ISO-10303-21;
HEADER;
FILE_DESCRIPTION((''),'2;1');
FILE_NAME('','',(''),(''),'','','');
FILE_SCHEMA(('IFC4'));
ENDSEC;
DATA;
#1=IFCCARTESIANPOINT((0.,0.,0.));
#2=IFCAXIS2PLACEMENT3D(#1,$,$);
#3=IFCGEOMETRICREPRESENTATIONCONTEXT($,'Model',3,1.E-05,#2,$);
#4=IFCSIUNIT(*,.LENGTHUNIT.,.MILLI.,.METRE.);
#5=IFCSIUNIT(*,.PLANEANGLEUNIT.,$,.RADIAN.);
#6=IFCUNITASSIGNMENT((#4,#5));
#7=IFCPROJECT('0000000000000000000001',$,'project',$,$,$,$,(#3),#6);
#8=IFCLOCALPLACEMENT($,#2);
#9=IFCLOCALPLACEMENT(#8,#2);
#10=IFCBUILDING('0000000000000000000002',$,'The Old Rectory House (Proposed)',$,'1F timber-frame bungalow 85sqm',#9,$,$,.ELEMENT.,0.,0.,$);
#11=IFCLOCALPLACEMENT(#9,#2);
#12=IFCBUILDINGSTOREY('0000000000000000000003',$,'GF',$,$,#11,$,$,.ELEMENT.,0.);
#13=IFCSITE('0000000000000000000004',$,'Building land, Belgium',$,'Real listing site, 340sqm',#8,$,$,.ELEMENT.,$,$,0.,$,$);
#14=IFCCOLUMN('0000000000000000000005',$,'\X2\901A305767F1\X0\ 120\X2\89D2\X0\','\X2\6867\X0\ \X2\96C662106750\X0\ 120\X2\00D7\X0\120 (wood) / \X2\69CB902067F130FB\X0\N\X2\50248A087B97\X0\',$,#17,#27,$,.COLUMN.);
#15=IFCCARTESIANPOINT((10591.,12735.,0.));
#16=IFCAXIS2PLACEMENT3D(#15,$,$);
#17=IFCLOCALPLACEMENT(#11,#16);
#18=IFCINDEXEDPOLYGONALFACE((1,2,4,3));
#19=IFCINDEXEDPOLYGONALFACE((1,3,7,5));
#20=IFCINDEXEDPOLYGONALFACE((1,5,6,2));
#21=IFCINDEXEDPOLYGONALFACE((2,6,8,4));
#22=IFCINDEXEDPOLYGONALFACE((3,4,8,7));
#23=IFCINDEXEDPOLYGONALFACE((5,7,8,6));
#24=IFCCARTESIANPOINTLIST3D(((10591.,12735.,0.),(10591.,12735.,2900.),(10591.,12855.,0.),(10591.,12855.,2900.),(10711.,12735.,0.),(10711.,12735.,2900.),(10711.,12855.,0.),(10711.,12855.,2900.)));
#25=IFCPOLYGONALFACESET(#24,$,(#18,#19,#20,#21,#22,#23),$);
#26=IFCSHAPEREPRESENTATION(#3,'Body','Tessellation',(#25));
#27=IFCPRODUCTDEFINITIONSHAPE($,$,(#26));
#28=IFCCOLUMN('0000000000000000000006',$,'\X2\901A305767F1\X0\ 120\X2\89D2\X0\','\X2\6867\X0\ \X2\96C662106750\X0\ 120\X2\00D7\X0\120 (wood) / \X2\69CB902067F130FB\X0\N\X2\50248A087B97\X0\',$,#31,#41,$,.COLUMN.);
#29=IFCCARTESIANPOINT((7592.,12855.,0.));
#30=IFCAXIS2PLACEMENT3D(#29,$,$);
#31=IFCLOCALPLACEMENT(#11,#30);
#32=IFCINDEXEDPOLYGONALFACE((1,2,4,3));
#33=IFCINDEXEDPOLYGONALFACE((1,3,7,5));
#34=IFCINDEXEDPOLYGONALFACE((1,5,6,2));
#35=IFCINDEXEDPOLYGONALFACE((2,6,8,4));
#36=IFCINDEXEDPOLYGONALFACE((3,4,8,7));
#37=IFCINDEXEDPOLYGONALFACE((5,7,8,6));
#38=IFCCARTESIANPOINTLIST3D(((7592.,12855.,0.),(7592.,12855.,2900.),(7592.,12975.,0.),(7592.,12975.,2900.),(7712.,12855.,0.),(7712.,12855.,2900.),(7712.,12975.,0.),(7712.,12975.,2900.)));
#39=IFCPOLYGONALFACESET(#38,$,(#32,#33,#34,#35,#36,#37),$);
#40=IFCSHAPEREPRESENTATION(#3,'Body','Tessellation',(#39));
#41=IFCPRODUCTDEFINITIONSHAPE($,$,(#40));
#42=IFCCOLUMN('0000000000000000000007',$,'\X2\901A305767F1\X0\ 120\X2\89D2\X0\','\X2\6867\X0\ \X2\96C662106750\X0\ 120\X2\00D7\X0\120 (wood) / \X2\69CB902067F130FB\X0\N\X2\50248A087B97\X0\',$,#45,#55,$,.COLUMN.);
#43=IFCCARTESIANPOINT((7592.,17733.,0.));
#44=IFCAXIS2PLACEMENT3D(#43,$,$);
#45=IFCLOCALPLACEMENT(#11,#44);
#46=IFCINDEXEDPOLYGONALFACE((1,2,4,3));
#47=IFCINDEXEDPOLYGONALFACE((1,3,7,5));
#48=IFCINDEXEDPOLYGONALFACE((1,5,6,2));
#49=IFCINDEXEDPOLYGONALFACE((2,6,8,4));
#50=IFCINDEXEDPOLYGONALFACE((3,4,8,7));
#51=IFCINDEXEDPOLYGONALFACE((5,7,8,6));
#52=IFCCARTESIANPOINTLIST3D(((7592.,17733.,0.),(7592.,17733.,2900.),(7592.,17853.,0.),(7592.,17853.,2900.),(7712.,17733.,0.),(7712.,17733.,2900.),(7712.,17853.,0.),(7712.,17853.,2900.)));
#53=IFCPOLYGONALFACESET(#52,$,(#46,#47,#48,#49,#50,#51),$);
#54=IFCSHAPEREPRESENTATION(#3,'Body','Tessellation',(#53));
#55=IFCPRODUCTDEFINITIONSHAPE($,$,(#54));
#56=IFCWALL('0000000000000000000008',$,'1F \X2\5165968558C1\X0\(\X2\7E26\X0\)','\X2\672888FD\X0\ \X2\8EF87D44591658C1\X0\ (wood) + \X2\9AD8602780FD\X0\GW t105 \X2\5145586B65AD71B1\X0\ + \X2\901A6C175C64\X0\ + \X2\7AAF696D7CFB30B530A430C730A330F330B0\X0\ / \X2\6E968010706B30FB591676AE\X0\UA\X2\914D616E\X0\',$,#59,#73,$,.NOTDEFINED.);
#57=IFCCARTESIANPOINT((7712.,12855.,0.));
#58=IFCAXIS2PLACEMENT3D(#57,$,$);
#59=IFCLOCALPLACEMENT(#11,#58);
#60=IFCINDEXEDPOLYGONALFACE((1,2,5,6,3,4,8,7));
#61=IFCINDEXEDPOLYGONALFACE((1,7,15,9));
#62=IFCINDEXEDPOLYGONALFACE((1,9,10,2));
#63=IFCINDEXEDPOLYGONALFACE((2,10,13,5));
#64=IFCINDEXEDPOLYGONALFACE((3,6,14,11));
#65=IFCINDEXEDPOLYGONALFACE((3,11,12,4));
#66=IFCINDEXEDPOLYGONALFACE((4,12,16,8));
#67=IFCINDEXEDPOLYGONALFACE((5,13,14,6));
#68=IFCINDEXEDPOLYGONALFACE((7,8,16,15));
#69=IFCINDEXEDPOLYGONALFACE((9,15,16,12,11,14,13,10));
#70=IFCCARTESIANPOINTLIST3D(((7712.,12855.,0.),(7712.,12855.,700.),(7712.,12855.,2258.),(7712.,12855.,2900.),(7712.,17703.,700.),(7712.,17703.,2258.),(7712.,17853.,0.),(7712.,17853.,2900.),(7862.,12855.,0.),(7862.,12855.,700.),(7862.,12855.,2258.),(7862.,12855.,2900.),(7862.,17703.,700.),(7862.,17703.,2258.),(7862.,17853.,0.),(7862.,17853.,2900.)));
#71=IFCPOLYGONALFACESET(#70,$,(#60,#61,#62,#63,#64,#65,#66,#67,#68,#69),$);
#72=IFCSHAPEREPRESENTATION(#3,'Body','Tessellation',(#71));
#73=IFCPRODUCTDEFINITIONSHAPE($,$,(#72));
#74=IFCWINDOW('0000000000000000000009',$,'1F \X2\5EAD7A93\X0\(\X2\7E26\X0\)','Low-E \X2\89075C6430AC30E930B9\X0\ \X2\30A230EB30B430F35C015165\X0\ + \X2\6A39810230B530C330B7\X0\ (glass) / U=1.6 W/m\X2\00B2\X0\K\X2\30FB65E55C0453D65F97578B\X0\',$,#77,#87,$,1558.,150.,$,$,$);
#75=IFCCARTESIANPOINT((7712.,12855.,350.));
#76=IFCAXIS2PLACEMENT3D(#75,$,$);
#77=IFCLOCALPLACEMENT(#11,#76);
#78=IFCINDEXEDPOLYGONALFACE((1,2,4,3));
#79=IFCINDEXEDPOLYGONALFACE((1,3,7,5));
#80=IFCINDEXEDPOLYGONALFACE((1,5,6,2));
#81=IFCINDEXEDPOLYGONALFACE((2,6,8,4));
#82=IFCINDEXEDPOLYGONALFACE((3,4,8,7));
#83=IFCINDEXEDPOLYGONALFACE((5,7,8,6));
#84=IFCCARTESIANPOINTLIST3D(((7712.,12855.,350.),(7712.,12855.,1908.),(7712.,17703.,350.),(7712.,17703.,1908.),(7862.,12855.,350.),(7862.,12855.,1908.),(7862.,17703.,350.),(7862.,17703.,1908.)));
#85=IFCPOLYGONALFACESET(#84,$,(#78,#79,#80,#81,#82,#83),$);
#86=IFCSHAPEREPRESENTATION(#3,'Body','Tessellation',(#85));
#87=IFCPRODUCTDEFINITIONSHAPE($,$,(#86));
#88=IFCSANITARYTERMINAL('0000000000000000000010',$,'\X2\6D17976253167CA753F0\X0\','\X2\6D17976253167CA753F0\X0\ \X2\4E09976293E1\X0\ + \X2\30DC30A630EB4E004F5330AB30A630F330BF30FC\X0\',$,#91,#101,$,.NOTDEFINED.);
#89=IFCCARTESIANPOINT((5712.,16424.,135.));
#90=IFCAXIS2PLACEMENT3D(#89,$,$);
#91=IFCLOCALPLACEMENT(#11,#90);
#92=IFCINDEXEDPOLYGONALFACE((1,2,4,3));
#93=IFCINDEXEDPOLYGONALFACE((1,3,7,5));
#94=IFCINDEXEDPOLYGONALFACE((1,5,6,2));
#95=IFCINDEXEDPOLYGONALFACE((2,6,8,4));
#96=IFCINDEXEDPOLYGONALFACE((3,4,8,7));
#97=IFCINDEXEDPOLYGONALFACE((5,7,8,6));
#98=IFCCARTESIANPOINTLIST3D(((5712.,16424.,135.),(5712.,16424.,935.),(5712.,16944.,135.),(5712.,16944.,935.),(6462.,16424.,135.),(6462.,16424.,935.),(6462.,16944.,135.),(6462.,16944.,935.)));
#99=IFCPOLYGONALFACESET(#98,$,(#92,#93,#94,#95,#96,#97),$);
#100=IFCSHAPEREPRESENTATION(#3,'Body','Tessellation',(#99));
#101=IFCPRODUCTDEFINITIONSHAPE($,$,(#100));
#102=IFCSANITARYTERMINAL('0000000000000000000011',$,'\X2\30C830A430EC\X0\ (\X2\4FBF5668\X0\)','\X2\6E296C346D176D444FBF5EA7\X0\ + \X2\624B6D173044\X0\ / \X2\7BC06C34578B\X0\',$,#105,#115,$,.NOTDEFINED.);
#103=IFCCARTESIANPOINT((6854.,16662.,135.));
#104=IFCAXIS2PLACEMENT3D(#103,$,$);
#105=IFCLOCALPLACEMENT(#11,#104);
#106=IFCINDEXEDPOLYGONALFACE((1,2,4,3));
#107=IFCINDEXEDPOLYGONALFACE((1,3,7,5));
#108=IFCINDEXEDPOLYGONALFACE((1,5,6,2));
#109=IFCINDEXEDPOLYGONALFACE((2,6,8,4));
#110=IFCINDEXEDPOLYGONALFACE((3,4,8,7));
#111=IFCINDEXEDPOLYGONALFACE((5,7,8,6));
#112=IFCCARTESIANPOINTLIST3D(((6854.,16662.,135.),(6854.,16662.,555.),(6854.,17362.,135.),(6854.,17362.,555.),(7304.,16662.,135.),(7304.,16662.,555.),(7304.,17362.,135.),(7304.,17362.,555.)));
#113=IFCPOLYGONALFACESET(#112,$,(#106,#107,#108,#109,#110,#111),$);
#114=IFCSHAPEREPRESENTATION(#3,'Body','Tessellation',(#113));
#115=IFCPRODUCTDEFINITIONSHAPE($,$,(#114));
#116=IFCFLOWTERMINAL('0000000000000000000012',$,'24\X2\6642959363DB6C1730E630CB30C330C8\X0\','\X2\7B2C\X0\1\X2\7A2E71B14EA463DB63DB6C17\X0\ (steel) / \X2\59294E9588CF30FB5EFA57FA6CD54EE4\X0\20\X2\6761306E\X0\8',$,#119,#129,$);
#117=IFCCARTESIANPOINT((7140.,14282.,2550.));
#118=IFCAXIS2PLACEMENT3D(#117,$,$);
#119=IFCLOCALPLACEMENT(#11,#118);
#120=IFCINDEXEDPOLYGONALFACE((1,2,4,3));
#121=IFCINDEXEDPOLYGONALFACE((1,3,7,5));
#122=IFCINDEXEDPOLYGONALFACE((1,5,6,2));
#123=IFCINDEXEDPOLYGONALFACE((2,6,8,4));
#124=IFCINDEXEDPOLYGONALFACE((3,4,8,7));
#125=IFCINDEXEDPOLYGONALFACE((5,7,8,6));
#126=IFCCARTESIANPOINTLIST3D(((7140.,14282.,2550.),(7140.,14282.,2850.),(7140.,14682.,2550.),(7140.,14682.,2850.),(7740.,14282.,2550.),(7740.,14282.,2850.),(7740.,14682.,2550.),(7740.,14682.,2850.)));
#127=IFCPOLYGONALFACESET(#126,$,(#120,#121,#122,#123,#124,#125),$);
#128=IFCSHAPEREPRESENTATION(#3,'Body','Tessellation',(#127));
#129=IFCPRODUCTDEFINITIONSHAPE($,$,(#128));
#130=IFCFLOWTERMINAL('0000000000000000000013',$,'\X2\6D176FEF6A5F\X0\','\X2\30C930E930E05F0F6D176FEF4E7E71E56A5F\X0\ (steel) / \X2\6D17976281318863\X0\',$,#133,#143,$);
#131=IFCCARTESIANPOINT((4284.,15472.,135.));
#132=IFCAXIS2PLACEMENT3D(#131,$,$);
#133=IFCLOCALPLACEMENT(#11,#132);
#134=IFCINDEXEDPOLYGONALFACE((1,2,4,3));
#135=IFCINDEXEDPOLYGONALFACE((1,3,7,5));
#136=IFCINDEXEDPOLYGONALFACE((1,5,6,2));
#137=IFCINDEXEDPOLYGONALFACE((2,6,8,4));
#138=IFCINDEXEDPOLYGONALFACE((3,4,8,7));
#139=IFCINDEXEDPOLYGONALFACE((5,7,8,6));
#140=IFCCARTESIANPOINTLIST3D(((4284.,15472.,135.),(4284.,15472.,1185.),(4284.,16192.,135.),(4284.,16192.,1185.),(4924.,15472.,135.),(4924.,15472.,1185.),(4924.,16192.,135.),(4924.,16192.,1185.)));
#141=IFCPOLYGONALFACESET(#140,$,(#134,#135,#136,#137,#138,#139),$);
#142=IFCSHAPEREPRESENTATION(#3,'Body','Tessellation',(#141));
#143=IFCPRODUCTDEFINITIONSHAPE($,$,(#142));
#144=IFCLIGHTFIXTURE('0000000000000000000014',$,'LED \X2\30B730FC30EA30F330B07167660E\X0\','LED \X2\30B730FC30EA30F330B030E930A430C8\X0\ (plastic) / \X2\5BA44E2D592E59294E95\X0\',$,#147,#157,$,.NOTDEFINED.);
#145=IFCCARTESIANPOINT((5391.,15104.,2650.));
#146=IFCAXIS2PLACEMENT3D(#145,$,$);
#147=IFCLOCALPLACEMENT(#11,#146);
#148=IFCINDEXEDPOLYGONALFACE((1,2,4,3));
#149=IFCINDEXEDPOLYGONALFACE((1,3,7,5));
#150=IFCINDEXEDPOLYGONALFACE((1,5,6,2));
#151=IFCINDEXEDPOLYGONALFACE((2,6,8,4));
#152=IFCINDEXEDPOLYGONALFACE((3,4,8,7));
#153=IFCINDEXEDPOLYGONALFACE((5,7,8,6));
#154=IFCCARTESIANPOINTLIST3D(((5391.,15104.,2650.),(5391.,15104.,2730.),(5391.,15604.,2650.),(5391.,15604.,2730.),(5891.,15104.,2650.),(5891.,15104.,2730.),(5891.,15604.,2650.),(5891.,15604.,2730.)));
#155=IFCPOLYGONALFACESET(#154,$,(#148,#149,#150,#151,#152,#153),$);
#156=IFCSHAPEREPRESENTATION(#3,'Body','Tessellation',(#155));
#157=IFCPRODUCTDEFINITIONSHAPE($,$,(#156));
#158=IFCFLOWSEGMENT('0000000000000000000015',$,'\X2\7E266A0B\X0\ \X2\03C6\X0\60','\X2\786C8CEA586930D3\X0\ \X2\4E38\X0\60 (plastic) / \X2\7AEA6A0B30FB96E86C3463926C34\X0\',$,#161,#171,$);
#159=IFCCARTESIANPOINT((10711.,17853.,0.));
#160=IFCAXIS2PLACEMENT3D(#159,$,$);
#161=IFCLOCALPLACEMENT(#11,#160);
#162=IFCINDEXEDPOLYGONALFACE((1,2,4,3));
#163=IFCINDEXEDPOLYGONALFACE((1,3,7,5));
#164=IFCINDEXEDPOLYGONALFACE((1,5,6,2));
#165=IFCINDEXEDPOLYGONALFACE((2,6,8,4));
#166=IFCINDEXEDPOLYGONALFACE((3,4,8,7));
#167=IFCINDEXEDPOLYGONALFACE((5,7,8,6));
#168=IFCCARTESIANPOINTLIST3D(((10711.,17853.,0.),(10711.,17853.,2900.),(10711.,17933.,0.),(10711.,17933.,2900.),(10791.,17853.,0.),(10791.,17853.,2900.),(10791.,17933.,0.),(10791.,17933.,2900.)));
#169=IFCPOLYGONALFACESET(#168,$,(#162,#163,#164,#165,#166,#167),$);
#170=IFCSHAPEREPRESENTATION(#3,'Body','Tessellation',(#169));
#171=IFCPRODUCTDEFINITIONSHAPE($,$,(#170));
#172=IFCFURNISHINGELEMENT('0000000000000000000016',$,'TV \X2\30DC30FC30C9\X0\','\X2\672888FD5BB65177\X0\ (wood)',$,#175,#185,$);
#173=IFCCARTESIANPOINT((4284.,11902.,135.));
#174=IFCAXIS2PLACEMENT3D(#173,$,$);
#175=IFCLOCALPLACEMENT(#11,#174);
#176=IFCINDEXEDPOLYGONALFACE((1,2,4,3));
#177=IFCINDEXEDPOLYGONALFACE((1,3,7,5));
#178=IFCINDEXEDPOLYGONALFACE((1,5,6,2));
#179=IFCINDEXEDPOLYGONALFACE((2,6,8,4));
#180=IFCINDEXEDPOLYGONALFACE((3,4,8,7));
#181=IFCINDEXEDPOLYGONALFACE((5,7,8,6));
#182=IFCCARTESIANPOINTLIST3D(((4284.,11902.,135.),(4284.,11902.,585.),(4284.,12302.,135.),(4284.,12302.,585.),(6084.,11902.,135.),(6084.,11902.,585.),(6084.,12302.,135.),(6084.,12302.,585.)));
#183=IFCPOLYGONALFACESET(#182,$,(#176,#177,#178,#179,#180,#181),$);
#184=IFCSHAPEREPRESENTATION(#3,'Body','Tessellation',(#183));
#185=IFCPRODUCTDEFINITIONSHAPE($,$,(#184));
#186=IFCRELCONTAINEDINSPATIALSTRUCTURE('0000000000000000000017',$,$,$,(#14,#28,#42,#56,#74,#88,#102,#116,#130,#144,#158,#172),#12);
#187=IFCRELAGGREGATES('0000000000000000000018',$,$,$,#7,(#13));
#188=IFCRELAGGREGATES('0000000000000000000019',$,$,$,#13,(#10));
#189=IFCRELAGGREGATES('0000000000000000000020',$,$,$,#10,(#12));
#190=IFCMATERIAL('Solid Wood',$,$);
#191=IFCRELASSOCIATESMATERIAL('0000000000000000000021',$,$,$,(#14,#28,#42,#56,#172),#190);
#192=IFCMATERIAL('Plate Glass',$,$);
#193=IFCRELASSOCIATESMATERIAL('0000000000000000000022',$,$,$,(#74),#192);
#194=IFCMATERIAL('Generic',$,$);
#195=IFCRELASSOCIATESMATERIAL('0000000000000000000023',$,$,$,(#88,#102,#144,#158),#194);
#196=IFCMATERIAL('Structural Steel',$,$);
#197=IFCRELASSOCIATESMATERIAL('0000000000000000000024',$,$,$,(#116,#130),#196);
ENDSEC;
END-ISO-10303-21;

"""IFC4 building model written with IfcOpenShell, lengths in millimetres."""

from ifc_helpers import new_model, si_unit, frame, frame_2d, origin, place, context, project, spatial, rectangle, extrude, material, element, fill, save


model = new_model("IFC4")

# Units and contexts
model_context = context("Model", 3, precision=1e-05, world=origin())
ifc_project = project(units=[si_unit("LENGTHUNIT", "METRE", prefix="MILLI"), si_unit("PLANEANGLEUNIT", "RADIAN")], contexts=[model_context])

# Site, building, storey
site_placement = place(None, origin())
site = spatial("IfcSite", under=ifc_project, at=site_placement, Name="Building land, Belgium", ObjectType="Real listing site, 340sqm", CompositionType="ELEMENT", RefElevation=0.0)
building_placement = place(site_placement, origin())
building = spatial("IfcBuilding", under=site, at=building_placement, Name="The Old Rectory House (Proposed)", ObjectType="1F timber-frame bungalow 85sqm", CompositionType="ELEMENT", ElevationOfRefHeight=0.0, ElevationOfTerrain=0.0)
storey_placement = place(building_placement, origin())
storey = spatial("IfcBuildingStorey", under=building, at=storey_placement, Name="GF", CompositionType="ELEMENT", Elevation=0.0)

# Columns
ifc_material_1 = material(Name="Solid Wood")
column_1_placement = place(storey_placement, frame((10591.0, 12735.0, 0.0)))
element("IfcColumn", 1, at=column_1_placement, inside=storey, material=ifc_material_1, Name="通し柱 120角", Description="桧 集成材 120×120 (wood) / 構造柱・N値計算", PredefinedType="COLUMN", context=model_context, shape_type="SweptSolid", body=[
    extrude(rectangle(XDim=120.0, YDim=120.0, at=frame_2d((60.0, 60.0))), frame((10591.0, 12735.0, 0.0)), (0.0, 0.0, 1.0), 2900.0),
])
column_2_placement = place(storey_placement, frame((7592.0, 12855.0, 0.0)))
element("IfcColumn", 2, at=column_2_placement, inside=storey, material=ifc_material_1, Name="通し柱 120角", Description="桧 集成材 120×120 (wood) / 構造柱・N値計算", PredefinedType="COLUMN", context=model_context, shape_type="SweptSolid", body=[
    extrude(rectangle(XDim=120.0, YDim=120.0, at=frame_2d((60.0, 60.0))), frame((7592.0, 12855.0, 0.0)), (0.0, 0.0, 1.0), 2900.0),
])
column_3_placement = place(storey_placement, frame((7592.0, 17733.0, 0.0)))
element("IfcColumn", 3, at=column_3_placement, inside=storey, material=ifc_material_1, Name="通し柱 120角", Description="桧 集成材 120×120 (wood) / 構造柱・N値計算", PredefinedType="COLUMN", context=model_context, shape_type="SweptSolid", body=[
    extrude(rectangle(XDim=120.0, YDim=120.0, at=frame_2d((60.0, 60.0))), frame((7592.0, 17733.0, 0.0)), (0.0, 0.0, 1.0), 2900.0),
])

# Wall, opening, window
wall_1_placement = place(storey_placement, frame((7712.0, 12855.0, 0.0)))
wall_1 = element("IfcWall", 4, at=wall_1_placement, inside=storey, material=ifc_material_1, Name="1F 入隅壁(縦)", Description="木製 軸組外壁 (wood) + 高性能GW t105 充填断熱 + 通気層 + 窯業系サイディング / 準耐火・外皮UA配慮", PredefinedType="NOTDEFINED", context=model_context, shape_type="SweptSolid", body=[
    extrude(rectangle(XDim=150.0, YDim=4998.0, at=frame_2d((75.0, 2499.0))), frame((7712.0, 12855.0, 0.0)), (0.0, 0.0, 1.0), 2900.0),
])
opening_placement = place(storey_placement, frame((7712.0, 12855.0, 350.0)))
opening = element("IfcOpeningElement", 5, at=opening_placement, cuts=wall_1, PredefinedType="NOTDEFINED", context=model_context, shape_type="SweptSolid", body=[
    extrude(rectangle(XDim=150.0, YDim=4848.0, at=frame_2d((75.0, 2424.0))), frame((7712.0, 12855.0, 350.0)), (0.0, 0.0, 1.0), 1558.0),
])
ifc_material_2 = material(Name="Plate Glass")
window_placement = place(storey_placement, frame((7712.0, 12855.0, 350.0)))
window = element("IfcWindow", 6, at=window_placement, inside=storey, material=ifc_material_2, Name="1F 庭窓(縦)", Description="Low-E 複層ガラス アルゴン封入 + 樹脂サッシ (glass) / U=1.6 W/m²K・日射取得型", OverallHeight=1558.0, OverallWidth=150.0, context=model_context, shape_type="SweptSolid", body=[
    extrude(rectangle(XDim=150.0, YDim=4848.0, at=frame_2d((75.0, 2424.0))), frame((7712.0, 12855.0, 350.0)), (0.0, 0.0, 1.0), 1558.0),
])
fill(opening, window)

# Sanitary terminals
ifc_material_3 = material(Name="Generic")
sanitary_terminal_1_placement = place(storey_placement, frame((5712.0, 16424.0, 135.0)))
element("IfcSanitaryTerminal", 7, at=sanitary_terminal_1_placement, inside=storey, material=ifc_material_3, Name="洗面化粧台", Description="洗面化粧台 三面鏡 + ボウル一体カウンター", PredefinedType="NOTDEFINED", context=model_context, shape_type="SweptSolid", body=[
    extrude(rectangle(XDim=750.0, YDim=520.0, at=frame_2d((375.0, 260.0))), frame((5712.0, 16424.0, 135.0)), (0.0, 0.0, 1.0), 800.0),
])
sanitary_terminal_2_placement = place(storey_placement, frame((6854.0, 16662.0, 135.0)))
element("IfcSanitaryTerminal", 8, at=sanitary_terminal_2_placement, inside=storey, material=ifc_material_3, Name="トイレ (便器)", Description="温水洗浄便座 + 手洗い / 節水型", PredefinedType="NOTDEFINED", context=model_context, shape_type="SweptSolid", body=[
    extrude(rectangle(XDim=450.0, YDim=700.0, at=frame_2d((225.0, 350.0))), frame((6854.0, 16662.0, 135.0)), (0.0, 0.0, 1.0), 420.0),
])

# Flow terminals
ifc_material_4 = material(Name="Structural Steel")
flow_terminal_1_placement = place(storey_placement, frame((7140.0, 14282.0, 2550.0)))
element("IfcFlowTerminal", 9, at=flow_terminal_1_placement, inside=storey, material=ifc_material_4, Name="24時間換気ユニット", Description="第1種熱交換換気 (steel) / 天井裏・建基法令20条の8", context=model_context, shape_type="SweptSolid", body=[
    extrude(rectangle(XDim=600.0, YDim=400.0, at=frame_2d((300.0, 200.0))), frame((7140.0, 14282.0, 2550.0)), (0.0, 0.0, 1.0), 300.0),
])
flow_terminal_2_placement = place(storey_placement, frame((4284.0, 15472.0, 135.0)))
element("IfcFlowTerminal", 10, at=flow_terminal_2_placement, inside=storey, material=ifc_material_4, Name="洗濯機", Description="ドラム式洗濯乾燥機 (steel) / 洗面脱衣", context=model_context, shape_type="SweptSolid", body=[
    extrude(rectangle(XDim=640.0, YDim=720.0, at=frame_2d((320.0, 360.0))), frame((4284.0, 15472.0, 135.0)), (0.0, 0.0, 1.0), 1050.0),
])

# Light fixture
light_fixture_placement = place(storey_placement, frame((5391.0, 15104.0, 2650.0)))
element("IfcLightFixture", 11, at=light_fixture_placement, inside=storey, material=ifc_material_3, Name="LED シーリング照明", Description="LED シーリングライト (plastic) / 室中央天井", PredefinedType="NOTDEFINED", context=model_context, shape_type="SweptSolid", body=[
    extrude(rectangle(XDim=500.0, YDim=500.0, at=frame_2d((250.0, 250.0))), frame((5391.0, 15104.0, 2650.0)), (0.0, 0.0, 1.0), 80.0),
])

# Flow segment
flow_segment_placement = place(storey_placement, frame((10711.0, 17853.0, 0.0)))
element("IfcFlowSegment", 12, at=flow_segment_placement, inside=storey, material=ifc_material_3, Name="縦樋 φ60", Description="硬質塩ビ 丸60 (plastic) / 竪樋・雨水排水", context=model_context, shape_type="SweptSolid", body=[
    extrude(rectangle(XDim=80.0, YDim=80.0, at=frame_2d((40.0, 40.0))), frame((10711.0, 17853.0, 0.0)), (0.0, 0.0, 1.0), 2900.0),
])

# Furnishing element
furnishing_placement = place(storey_placement, frame((4284.0, 11902.0, 135.0)))
element("IfcFurnishingElement", 13, at=furnishing_placement, inside=storey, material=ifc_material_1, Name="TV ボード", Description="木製家具 (wood)", context=model_context, shape_type="SweptSolid", body=[
    extrude(rectangle(XDim=1800.0, YDim=400.0, at=frame_2d((900.0, 200.0))), frame((4284.0, 11902.0, 135.0)), (0.0, 0.0, 1.0), 450.0),
])

save(model, "model.ifc")
